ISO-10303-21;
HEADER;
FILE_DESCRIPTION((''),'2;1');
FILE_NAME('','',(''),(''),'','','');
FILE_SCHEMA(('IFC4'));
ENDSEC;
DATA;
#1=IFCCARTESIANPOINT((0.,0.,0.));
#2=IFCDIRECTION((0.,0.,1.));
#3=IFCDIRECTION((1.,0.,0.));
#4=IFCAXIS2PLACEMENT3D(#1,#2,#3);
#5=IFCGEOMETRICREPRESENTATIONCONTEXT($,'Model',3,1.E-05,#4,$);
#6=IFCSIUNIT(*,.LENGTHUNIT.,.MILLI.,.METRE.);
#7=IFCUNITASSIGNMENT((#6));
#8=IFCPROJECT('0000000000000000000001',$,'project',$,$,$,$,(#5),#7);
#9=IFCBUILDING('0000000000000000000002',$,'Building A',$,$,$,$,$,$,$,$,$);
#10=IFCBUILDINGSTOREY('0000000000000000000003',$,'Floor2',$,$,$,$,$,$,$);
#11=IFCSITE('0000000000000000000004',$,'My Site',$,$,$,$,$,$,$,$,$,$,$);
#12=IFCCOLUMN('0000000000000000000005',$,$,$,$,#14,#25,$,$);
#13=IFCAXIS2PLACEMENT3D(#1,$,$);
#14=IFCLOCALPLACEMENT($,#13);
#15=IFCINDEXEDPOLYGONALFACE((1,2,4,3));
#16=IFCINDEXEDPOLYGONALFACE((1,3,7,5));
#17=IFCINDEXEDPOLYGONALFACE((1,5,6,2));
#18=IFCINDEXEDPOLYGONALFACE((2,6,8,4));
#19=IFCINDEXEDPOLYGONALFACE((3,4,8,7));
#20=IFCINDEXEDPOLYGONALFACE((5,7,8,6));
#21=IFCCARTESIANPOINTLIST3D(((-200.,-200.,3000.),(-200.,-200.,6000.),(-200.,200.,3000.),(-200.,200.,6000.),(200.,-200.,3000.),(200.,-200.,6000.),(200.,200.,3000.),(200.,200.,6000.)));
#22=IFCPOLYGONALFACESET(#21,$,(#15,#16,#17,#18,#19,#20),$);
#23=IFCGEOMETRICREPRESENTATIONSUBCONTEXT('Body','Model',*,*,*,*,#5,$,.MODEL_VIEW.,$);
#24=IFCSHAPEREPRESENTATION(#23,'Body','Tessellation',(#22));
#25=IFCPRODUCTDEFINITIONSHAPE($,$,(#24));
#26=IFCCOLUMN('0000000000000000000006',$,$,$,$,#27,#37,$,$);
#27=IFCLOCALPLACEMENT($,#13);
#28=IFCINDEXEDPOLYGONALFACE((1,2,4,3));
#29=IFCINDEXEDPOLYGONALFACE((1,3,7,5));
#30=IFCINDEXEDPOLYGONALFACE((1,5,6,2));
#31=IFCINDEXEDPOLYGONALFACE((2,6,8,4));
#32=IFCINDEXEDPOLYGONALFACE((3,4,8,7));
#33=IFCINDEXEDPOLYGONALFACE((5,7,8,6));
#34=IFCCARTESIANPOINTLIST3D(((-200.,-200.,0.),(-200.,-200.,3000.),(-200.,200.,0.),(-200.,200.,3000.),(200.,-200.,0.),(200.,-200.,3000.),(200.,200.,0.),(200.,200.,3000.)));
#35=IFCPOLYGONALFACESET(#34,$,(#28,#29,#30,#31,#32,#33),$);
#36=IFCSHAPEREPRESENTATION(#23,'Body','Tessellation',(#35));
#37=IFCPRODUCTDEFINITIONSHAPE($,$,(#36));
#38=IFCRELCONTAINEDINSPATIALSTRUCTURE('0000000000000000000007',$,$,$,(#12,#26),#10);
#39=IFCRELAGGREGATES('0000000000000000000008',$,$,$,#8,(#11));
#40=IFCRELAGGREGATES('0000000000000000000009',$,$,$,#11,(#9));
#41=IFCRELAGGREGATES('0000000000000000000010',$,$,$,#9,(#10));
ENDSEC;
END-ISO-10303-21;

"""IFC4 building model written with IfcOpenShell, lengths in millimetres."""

from ifc_helpers import new_model, si_unit, frame, origin_with_axes, place, context, subcontext, project, spatial, line, indexed_curve, outline, extrude, element, save


model = new_model("IFC4")

# Units and contexts
model_context = context("Model", 3, precision=1e-05, world=origin_with_axes())
body_context = subcontext(model_context, "Body", "Model", "MODEL_VIEW")
ifc_project = project(units=[si_unit("LENGTHUNIT", "METRE", prefix="MILLI")], contexts=[model_context])

# Site, building, storey
site = spatial("IfcSite", under=ifc_project, Name="My Site")
building = spatial("IfcBuilding", under=site, Name="Building A")
storey = spatial("IfcBuildingStorey", under=building, Name="Floor2")

# Columns
for number, where, z_axis, x_axis in (
    (1, (0.0, 0.0, 3000.0), (0.0, 0.0, 1.0), (1.0, 0.0, 0.0)),
    (2, (0.0, 0.0, 0.0), (0.0, 0.0, 1.0), (1.0, 0.0, 0.0)),
):
    element("IfcColumn", number, at=place(None, frame(where, z_axis=z_axis, x_axis=x_axis)), inside=storey, context=body_context, shape_type="SweptSolid", body=[
        extrude(outline(indexed_curve([(-200.0, -200.0), (200.0, -200.0), (200.0, 200.0), (-200.0, 200.0)], segments=[line(1, 2, 3, 4, 1)])), origin_with_axes(), (0.0, 0.0, 1.0), 3000.0),
    ])

save(model, "model.ifc")
